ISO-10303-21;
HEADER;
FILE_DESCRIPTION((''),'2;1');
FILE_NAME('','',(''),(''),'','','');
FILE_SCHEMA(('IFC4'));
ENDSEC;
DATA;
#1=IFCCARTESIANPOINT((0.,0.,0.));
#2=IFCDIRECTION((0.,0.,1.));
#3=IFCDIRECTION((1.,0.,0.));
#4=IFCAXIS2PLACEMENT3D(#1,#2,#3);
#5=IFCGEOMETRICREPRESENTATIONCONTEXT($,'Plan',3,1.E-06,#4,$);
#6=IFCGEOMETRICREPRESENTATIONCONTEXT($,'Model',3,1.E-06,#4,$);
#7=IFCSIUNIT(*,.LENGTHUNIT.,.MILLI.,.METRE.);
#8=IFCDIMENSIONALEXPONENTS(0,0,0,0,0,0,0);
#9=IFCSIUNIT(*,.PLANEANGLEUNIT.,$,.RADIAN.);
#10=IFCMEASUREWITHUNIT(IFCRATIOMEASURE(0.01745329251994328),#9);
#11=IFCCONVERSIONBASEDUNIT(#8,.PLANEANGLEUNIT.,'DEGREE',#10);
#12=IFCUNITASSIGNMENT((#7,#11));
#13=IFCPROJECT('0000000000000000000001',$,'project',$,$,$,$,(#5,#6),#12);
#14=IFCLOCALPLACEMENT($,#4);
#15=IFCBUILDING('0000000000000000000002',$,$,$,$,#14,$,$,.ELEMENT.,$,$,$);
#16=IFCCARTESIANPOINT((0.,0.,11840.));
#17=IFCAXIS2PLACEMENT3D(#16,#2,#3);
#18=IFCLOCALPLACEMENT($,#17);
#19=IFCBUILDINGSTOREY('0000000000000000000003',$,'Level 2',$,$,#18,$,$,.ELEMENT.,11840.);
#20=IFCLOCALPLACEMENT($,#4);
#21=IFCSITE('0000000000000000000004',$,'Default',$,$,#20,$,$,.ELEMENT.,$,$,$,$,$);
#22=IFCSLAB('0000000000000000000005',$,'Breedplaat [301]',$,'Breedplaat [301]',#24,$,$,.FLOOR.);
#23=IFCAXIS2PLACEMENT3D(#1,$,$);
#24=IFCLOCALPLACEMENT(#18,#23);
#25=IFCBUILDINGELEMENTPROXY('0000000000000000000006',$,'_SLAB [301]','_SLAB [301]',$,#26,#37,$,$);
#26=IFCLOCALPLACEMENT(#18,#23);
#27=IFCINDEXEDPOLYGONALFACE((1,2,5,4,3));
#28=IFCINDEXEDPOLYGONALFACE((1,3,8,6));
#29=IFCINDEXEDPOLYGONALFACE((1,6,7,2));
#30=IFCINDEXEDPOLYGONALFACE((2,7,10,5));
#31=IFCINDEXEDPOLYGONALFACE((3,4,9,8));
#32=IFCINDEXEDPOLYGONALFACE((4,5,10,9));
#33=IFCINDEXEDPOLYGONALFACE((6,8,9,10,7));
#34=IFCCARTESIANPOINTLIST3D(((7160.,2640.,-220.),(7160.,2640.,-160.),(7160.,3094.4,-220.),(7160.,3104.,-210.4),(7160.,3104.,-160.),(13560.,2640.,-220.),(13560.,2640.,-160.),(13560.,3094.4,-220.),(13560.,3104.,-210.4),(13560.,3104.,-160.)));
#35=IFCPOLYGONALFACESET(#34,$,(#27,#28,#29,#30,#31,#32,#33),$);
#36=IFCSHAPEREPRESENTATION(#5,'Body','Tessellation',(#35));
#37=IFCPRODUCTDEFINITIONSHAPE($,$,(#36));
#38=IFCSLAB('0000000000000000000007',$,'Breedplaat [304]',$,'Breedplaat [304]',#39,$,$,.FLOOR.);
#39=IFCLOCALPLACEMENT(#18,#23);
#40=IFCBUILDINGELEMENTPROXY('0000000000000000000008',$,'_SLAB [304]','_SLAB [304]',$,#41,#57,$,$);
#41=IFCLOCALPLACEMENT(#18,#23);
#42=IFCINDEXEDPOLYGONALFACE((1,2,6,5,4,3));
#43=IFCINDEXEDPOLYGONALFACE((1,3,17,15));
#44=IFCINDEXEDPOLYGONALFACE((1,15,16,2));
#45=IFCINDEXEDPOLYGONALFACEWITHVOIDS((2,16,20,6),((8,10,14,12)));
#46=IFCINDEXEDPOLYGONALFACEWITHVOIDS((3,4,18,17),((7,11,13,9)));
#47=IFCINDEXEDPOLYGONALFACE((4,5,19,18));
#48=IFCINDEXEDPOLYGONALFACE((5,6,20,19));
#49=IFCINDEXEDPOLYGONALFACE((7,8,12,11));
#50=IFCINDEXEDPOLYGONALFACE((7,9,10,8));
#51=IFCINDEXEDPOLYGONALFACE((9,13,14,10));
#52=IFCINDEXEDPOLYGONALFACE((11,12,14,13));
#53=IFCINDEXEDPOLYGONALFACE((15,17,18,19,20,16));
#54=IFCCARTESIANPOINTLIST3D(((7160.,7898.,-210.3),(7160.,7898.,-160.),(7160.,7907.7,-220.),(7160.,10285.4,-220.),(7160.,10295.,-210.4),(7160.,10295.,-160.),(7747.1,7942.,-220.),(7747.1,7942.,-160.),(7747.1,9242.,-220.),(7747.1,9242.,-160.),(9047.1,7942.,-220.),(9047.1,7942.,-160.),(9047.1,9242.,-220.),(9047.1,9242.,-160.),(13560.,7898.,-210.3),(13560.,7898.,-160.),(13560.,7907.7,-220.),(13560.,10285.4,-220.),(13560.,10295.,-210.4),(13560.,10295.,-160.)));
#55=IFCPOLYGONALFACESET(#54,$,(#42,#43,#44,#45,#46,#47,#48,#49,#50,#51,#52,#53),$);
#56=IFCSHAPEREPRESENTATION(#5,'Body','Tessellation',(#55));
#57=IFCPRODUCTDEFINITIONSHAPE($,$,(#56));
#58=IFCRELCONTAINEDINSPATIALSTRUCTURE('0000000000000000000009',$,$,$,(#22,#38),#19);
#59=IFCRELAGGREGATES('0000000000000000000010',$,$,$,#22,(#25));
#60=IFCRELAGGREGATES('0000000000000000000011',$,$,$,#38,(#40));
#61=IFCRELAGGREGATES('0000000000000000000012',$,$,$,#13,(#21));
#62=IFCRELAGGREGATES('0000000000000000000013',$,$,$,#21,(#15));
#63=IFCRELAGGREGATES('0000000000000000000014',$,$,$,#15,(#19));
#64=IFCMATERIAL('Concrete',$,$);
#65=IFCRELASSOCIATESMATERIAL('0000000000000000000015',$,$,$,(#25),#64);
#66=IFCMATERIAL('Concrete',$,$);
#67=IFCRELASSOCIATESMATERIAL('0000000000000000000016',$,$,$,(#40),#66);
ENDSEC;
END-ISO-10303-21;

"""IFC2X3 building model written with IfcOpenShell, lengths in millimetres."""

from ifc_helpers import new_model, entity, si_unit, converted_unit, frame, origin_with_axes, origin_2d_with_axis, place, context, project, spatial, polyline, rectangle, outline, extrude, material, element, aggregate, save


model = new_model("IFC2X3")

# Units and contexts
plan_context = context("Plan", 3, precision=1e-06, world=origin_with_axes())
model_context = context("Model", 3, precision=1e-06, world=origin_with_axes())
ifc_project = project(units=[si_unit("LENGTHUNIT", "METRE", prefix="MILLI"), converted_unit("PLANEANGLEUNIT", "DEGREE", entity("IfcRatioMeasure", 0.01745329251994328), si_unit("PLANEANGLEUNIT", "RADIAN"), dimensions=[0, 0, 0, 0, 0, 0, 0])], contexts=[plan_context, model_context])

# Site, building, storey
site_placement = place(None, origin_with_axes())
site = spatial("IfcSite", under=ifc_project, at=site_placement, Name="Default", CompositionType="ELEMENT")
building_placement = place(None, origin_with_axes())
building = spatial("IfcBuilding", under=site, at=building_placement, CompositionType="ELEMENT")
storey_placement = place(None, frame((0.0, 0.0, 11840.0), z_axis=(0.0, 0.0, 1.0), x_axis=(1.0, 0.0, 0.0)))
storey = spatial("IfcBuildingStorey", under=building, at=storey_placement, Name="Level 2", CompositionType="ELEMENT", Elevation=11840.0)

# Slab, building element proxy, opening
slab_1_placement = place(None, frame((7160.0, 2640.0, 11620.0), z_axis=(0.0, 0.0, 1.0), x_axis=(1.0, 0.0, 0.0)))
slab_1 = element("IfcSlab", 1, at=slab_1_placement, inside=storey, Name="Breedplaat [301]", ObjectType="Breedplaat [301]", PredefinedType="FLOOR")
ifc_material_1 = material(Name="Concrete")
proxy_1_placement = place(slab_1_placement, origin_with_axes())
proxy_1 = element("IfcBuildingElementProxy", 2, at=proxy_1_placement, material=ifc_material_1, Name="_SLAB [301]", Description="_SLAB [301]", context=plan_context, shape_type="SweptSolid", body=[
    extrude(outline(polyline([(6400.0, 464.0), (0.0, 464.0), (0.0, 0.0), (6400.0, 0.0), (6400.0, 464.0)])), origin_with_axes(), (0.0, 0.0, 1.0), 60.0),
])
opening_1_placement = place(None, frame((7160.0, 2640.0, 11620.0), z_axis=(0.0, 0.0, 1.0), x_axis=(1.0, 0.0, 0.0)))
element("IfcOpeningElement", 3, at=opening_1_placement, cuts=proxy_1, ObjectType="Opening", context=plan_context, shape_type="SweptSolid", body=[
    extrude(outline(polyline([(-0.1, -0.1), (-0.1, 10.0), (10.0, -0.1), (-0.1, -0.1)])), frame((6401.2, 464.2, -0.1), z_axis=(-1.0, 0.0, 0.0), x_axis=(0.0, -1.0, 0.0)), (0.0, 0.0, 1.0), 6402.2),
])
aggregate(slab_1, [proxy_1])

# Slab, building element proxy, openings
slab_2_placement = place(None, frame((7160.0, 7898.0, 11620.0), z_axis=(0.0, 0.0, 1.0), x_axis=(1.0, 0.0, 0.0)))
slab_2 = element("IfcSlab", 4, at=slab_2_placement, inside=storey, Name="Breedplaat [304]", ObjectType="Breedplaat [304]", PredefinedType="FLOOR")
ifc_material_2 = material(Name="Concrete")
proxy_2_placement = place(slab_2_placement, origin_with_axes())
proxy_2 = element("IfcBuildingElementProxy", 5, at=proxy_2_placement, material=ifc_material_2, Name="_SLAB [304]", Description="_SLAB [304]", context=plan_context, shape_type="SweptSolid", body=[
    extrude(outline(polyline([(6400.0, 2397.0), (0.0, 2397.0), (0.0, 0.0), (6400.0, 0.0), (6400.0, 2397.0)])), origin_with_axes(), (0.0, 0.0, 1.0), 60.0),
])
opening_2_placement = place(slab_2_placement, frame((587.1, 44.0, 0.0), z_axis=(0.0, 0.0, 1.0), x_axis=(1.0, 0.0, 0.0)))
element("IfcOpeningElement", 6, at=opening_2_placement, cuts=proxy_2, ObjectType="Opening", context=plan_context, shape_type="SolidModel", body=[
    extrude(rectangle(XDim=1300.0, YDim=1300.0, at=origin_2d_with_axis()), frame((650.0, 650.0, 0.0), z_axis=(0.0, 0.0, 1.0), x_axis=(1.0, 0.0, 0.0)), (0.0, 0.0, 1.0), 60.0),
])
opening_3_placement = place(None, frame((7160.0, 7898.0, 11620.0), z_axis=(0.0, 0.0, 1.0), x_axis=(1.0, 0.0, 0.0)))
element("IfcOpeningElement", 7, at=opening_3_placement, cuts=proxy_2, ObjectType="Opening", context=plan_context, shape_type="SweptSolid", body=[
    extrude(outline(polyline([(-0.1, -0.1), (-0.1, 10.0), (10.0, -0.1), (-0.1, -0.1)])), frame((-1.2, -0.1, -0.1), z_axis=(1.0, 0.0, 0.0), x_axis=(0.0, 1.0, 0.0)), (0.0, 0.0, 1.0), 6402.2),
])
opening_4_placement = place(None, frame((7160.0, 7898.0, 11620.0), z_axis=(0.0, 0.0, 1.0), x_axis=(1.0, 0.0, 0.0)))
element("IfcOpeningElement", 8, at=opening_4_placement, cuts=proxy_2, ObjectType="Opening", context=plan_context, shape_type="SweptSolid", body=[
    extrude(outline(polyline([(-0.1, -0.1), (-0.1, 10.0), (10.0, -0.1), (-0.1, -0.1)])), frame((6401.2, 2397.2, -0.1), z_axis=(-1.0, 0.0, 0.0), x_axis=(0.0, -1.0, 0.0)), (0.0, 0.0, 1.0), 6402.2),
])
aggregate(slab_2, [proxy_2])

save(model, "model.ifc")
